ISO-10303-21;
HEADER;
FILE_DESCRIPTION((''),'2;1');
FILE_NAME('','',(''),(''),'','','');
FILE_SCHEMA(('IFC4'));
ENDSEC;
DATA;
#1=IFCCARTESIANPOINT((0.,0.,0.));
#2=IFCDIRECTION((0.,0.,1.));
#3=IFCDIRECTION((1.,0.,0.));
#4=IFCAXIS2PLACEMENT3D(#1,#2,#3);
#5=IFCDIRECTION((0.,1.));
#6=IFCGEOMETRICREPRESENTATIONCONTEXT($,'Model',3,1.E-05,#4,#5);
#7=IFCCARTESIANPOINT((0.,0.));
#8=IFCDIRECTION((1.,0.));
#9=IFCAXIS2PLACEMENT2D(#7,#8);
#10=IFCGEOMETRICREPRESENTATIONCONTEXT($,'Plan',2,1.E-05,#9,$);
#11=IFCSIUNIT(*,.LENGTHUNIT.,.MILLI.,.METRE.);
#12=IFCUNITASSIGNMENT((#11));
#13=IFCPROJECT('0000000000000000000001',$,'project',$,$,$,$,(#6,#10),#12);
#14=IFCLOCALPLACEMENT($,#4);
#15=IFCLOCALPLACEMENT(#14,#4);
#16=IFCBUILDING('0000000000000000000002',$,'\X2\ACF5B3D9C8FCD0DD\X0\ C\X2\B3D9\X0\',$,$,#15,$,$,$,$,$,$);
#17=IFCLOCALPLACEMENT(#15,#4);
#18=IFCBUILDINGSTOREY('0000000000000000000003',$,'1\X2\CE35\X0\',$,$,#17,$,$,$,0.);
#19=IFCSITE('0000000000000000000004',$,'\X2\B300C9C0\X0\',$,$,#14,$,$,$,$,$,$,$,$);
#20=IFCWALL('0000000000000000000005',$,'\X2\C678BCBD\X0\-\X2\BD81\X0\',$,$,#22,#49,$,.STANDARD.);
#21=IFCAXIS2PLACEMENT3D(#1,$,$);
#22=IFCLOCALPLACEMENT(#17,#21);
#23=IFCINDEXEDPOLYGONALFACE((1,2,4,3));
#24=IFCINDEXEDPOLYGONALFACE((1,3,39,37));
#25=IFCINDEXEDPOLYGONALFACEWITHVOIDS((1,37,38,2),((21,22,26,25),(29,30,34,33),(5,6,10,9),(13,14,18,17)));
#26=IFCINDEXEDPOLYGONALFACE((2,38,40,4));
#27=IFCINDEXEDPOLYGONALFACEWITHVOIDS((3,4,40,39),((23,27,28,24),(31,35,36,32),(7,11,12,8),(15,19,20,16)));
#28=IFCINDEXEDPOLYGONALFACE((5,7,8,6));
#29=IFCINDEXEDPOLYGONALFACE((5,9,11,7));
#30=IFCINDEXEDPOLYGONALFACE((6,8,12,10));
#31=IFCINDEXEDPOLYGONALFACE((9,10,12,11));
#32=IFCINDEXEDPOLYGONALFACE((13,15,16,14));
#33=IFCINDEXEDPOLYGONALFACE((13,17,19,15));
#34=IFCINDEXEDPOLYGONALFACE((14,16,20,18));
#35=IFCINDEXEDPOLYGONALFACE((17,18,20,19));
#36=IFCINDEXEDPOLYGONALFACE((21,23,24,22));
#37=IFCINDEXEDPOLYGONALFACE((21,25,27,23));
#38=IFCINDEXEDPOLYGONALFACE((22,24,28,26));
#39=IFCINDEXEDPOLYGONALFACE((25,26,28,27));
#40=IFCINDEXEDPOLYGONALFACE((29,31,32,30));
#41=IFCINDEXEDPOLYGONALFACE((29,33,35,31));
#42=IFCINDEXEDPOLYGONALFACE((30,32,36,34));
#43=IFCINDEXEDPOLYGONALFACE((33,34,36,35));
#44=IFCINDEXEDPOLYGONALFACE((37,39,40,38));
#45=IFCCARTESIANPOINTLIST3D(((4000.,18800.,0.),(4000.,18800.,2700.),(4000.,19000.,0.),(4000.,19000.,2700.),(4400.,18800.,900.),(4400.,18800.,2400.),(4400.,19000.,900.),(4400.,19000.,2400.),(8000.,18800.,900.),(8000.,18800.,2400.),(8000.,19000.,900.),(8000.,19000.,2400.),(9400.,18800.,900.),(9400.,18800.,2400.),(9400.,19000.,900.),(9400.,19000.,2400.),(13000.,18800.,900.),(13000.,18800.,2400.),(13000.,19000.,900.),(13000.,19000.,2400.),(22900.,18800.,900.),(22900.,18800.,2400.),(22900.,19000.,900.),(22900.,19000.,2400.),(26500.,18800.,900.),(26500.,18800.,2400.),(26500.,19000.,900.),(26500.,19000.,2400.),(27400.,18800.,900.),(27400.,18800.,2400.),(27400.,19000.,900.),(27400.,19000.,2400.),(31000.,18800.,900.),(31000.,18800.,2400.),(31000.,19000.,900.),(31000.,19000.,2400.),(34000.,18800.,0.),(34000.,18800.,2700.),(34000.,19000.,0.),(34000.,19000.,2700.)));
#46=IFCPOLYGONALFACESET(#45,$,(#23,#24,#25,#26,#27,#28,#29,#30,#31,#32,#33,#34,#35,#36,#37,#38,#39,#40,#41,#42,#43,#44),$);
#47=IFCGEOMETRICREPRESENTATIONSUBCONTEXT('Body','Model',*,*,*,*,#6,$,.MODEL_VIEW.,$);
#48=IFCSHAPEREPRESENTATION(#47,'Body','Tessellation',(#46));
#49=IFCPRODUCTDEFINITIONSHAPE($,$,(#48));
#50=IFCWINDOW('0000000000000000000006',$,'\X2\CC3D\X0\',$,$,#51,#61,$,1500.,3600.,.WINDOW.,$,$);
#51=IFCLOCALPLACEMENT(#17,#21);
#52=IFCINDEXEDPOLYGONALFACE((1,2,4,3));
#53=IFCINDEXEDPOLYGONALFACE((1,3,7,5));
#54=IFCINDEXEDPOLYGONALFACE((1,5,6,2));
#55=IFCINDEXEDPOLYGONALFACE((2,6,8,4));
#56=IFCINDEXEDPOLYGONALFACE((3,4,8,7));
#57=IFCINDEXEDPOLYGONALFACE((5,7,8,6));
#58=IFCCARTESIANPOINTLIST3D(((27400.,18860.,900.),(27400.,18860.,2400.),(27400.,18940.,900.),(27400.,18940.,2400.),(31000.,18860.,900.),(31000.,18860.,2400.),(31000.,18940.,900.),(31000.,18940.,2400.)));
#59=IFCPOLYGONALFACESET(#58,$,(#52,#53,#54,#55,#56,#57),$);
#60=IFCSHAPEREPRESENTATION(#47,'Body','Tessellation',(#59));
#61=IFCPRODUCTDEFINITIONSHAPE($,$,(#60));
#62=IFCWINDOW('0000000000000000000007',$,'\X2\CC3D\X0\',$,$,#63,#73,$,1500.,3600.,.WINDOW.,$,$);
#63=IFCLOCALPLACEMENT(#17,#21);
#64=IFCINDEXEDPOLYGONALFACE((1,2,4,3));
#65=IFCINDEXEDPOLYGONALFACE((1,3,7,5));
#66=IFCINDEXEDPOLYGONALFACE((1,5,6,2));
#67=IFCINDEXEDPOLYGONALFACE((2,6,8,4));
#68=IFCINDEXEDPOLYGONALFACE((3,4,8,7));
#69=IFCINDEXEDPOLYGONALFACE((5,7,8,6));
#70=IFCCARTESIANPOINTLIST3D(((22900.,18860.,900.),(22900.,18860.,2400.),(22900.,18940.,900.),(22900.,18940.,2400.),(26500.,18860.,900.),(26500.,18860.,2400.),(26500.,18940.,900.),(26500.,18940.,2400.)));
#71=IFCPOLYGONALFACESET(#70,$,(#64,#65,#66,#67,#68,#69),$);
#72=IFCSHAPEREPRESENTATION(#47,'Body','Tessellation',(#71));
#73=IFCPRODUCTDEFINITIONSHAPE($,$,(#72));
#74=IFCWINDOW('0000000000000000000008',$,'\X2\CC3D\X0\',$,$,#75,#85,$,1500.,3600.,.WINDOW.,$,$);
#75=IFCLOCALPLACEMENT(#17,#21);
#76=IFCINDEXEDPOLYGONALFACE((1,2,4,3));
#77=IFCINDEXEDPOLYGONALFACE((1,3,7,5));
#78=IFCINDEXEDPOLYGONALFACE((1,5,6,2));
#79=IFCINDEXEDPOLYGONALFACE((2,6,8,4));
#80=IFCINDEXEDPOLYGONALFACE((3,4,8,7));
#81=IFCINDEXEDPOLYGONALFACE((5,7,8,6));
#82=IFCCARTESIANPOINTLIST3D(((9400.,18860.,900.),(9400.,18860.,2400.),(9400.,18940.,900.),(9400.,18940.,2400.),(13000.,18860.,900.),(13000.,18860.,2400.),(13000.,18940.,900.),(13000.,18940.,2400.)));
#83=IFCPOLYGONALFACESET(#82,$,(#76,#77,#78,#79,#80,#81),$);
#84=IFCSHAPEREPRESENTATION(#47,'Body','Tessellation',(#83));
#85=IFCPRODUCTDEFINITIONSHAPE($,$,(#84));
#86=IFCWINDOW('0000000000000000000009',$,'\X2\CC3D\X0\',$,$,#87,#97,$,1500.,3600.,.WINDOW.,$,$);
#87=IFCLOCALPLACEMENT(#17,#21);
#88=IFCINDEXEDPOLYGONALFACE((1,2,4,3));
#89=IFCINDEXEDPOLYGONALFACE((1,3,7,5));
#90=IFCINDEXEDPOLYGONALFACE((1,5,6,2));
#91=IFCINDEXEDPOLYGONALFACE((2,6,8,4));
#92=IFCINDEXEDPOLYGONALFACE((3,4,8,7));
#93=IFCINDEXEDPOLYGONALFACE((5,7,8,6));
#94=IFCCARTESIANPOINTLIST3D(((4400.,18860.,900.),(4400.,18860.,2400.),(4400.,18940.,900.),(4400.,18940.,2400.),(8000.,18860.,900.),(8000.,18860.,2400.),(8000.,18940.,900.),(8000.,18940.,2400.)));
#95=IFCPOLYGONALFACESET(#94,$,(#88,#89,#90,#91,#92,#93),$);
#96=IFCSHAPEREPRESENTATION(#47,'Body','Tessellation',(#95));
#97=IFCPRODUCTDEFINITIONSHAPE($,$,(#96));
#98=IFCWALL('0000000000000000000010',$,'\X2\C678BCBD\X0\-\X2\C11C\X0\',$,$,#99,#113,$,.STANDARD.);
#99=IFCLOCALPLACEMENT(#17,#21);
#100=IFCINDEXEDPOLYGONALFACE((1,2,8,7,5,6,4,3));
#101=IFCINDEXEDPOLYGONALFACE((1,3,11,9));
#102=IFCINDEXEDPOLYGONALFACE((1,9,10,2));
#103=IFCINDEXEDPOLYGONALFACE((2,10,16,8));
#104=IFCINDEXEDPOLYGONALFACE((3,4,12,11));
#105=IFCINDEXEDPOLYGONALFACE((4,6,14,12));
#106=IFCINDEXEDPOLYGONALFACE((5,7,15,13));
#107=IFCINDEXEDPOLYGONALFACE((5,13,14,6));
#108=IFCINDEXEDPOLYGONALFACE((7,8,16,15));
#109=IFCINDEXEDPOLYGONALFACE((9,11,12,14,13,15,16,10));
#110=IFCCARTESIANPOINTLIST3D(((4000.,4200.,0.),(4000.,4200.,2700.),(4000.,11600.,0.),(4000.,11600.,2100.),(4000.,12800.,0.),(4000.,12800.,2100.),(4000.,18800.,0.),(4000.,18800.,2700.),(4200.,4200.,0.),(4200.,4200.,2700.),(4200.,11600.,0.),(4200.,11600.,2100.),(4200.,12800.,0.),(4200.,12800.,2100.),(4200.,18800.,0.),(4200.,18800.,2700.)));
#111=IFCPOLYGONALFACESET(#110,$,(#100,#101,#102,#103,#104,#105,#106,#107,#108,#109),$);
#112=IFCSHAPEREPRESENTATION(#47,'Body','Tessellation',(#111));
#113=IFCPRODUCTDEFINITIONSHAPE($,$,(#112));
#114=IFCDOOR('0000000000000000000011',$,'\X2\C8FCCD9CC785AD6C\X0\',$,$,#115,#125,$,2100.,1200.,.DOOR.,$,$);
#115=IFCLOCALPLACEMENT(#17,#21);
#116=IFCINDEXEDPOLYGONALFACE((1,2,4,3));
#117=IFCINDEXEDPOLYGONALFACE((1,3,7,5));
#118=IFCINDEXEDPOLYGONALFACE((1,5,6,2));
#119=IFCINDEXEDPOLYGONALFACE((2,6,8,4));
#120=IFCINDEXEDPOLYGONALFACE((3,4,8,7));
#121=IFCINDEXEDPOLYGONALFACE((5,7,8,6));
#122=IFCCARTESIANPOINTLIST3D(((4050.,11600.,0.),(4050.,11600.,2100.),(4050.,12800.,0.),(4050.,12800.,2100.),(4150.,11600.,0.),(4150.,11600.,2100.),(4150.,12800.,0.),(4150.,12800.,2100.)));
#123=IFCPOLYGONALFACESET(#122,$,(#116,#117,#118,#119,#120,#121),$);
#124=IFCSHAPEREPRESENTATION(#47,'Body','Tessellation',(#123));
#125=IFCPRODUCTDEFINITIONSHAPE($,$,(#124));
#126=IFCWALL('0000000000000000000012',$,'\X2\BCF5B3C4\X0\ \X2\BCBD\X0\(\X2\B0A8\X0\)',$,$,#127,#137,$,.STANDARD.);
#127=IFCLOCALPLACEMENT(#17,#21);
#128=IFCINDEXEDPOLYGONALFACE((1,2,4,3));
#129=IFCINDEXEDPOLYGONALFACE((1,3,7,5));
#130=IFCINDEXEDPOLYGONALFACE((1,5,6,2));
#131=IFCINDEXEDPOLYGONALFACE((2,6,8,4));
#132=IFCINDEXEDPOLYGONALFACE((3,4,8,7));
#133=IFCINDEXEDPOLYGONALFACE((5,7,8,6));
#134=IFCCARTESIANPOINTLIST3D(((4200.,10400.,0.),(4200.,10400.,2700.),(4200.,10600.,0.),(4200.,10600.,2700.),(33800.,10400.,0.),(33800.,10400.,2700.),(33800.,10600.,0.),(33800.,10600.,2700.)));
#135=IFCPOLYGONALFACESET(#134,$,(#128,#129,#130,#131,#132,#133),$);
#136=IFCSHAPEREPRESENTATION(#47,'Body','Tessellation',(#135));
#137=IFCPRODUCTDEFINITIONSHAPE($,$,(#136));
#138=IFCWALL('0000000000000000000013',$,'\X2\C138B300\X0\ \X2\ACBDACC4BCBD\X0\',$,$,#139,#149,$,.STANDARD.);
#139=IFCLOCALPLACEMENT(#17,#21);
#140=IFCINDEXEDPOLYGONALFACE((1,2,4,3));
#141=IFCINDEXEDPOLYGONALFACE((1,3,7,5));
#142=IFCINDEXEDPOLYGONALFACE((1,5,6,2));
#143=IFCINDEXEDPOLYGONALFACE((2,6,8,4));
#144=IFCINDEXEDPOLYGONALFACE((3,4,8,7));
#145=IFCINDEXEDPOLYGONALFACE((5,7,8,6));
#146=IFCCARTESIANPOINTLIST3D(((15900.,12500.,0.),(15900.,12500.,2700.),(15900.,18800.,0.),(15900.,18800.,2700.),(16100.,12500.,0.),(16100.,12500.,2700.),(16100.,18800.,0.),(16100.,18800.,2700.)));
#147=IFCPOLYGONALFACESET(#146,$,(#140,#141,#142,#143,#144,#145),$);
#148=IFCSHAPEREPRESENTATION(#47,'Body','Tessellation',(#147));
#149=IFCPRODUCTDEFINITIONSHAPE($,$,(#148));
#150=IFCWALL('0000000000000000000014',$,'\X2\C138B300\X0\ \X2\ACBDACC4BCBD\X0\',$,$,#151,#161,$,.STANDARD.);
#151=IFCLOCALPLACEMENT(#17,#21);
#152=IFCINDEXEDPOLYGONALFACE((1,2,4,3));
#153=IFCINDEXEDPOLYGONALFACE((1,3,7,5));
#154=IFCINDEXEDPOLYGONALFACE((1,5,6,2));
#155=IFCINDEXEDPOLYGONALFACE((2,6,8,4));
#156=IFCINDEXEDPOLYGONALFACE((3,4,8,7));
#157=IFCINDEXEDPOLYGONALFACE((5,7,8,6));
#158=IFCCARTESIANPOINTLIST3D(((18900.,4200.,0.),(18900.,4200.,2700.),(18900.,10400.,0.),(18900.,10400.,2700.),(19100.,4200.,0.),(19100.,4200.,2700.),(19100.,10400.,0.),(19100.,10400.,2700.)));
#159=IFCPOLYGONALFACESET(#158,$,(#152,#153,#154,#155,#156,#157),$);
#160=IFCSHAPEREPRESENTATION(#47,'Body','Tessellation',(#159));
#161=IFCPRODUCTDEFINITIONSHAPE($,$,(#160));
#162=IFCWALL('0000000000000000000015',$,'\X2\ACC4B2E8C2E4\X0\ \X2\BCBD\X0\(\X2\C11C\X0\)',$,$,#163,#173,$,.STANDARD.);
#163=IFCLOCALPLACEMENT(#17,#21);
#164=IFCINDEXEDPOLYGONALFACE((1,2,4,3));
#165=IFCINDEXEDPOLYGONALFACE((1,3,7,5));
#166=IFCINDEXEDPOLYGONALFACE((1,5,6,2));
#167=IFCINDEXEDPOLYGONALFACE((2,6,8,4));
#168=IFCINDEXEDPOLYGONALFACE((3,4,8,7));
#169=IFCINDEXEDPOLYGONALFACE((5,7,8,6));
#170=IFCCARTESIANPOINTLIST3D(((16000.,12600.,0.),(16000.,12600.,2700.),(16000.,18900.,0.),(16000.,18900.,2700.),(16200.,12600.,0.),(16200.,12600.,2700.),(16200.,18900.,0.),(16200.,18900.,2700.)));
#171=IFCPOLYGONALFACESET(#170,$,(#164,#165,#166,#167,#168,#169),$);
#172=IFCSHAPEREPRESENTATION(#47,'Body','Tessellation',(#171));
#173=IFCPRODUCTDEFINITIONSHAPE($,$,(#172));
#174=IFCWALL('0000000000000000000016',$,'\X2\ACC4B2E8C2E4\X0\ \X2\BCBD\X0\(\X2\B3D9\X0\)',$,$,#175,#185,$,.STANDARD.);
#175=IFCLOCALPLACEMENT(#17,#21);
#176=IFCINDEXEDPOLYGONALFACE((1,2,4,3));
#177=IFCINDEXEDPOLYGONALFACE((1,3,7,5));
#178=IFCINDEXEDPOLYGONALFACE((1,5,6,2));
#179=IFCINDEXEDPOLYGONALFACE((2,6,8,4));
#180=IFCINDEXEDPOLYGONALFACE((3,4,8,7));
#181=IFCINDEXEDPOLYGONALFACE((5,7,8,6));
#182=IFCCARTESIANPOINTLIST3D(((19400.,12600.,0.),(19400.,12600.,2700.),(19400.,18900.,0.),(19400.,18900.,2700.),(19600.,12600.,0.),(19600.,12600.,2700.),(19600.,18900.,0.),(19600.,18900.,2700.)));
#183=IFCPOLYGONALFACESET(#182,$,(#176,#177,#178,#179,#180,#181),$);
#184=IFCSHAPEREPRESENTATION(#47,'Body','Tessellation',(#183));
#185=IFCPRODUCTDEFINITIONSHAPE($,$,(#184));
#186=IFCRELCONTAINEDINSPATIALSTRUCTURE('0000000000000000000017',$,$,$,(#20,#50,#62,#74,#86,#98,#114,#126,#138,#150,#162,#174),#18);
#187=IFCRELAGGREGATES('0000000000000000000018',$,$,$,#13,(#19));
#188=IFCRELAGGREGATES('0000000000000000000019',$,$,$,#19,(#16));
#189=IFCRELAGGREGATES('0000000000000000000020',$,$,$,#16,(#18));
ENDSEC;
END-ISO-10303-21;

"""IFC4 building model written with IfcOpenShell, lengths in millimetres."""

from ifc_helpers import new_model, si_unit, direction, frame, origin_with_axes, origin_2d_with_axis, place, context, subcontext, project, spatial, polyline, outline, extrude, element, fill, save


model = new_model("IFC4")

# Units and contexts
model_context = context("Model", 3, precision=1e-05, world=origin_with_axes(), true_north=direction((0.0, 1.0)))
plan_context = context("Plan", 2, precision=1e-05, world=origin_2d_with_axis())
body_context = subcontext(model_context, "Body", "Model", "MODEL_VIEW")
ifc_project = project(units=[si_unit("LENGTHUNIT", "METRE", prefix="MILLI")], contexts=[model_context, plan_context])

# Site, building, storey
site_placement = place(None, origin_with_axes())
site = spatial("IfcSite", under=ifc_project, at=site_placement, Name="대지")
building_placement = place(site_placement, origin_with_axes())
building = spatial("IfcBuilding", under=site, at=building_placement, Name="공동주택 C동")
storey_placement = place(building_placement, origin_with_axes())
storey = spatial("IfcBuildingStorey", under=building, at=storey_placement, Name="1층", Elevation=0.0)

# Wall, openings, windows
wall_1_placement = place(storey_placement, origin_with_axes())
wall_1 = element("IfcWall", 1, at=wall_1_placement, inside=storey, Name="외벽-북", PredefinedType="STANDARD", context=body_context, shape_type="SweptSolid", body=[
    extrude(outline(polyline([(34000.0, 18800.0), (4000.0, 18800.0), (4000.0, 19000.0), (34000.0, 19000.0), (34000.0, 18800.0)])), origin_with_axes(), (0.0, 0.0, 1.0), 2700.0),
])
opening_1_placement = place(storey_placement, origin_with_axes())
opening_1 = element("IfcOpeningElement", 2, at=opening_1_placement, cuts=wall_1, PredefinedType="OPENING", context=body_context, shape_type="SweptSolid", body=[
    extrude(outline(polyline([(31000.0, 19050.0), (27400.0, 19050.0), (27400.0, 18750.0), (31000.0, 18750.0), (31000.0, 19050.0)])), frame((0.0, 0.0, 900.0), z_axis=(0.0, 0.0, 1.0), x_axis=(1.0, 0.0, 0.0)), (0.0, 0.0, 1.0), 1500.0),
])
opening_2_placement = place(storey_placement, origin_with_axes())
opening_2 = element("IfcOpeningElement", 3, at=opening_2_placement, cuts=wall_1, PredefinedType="OPENING", context=body_context, shape_type="SweptSolid", body=[
    extrude(outline(polyline([(26500.0, 19050.0), (22900.0, 19050.0), (22900.0, 18750.0), (26500.0, 18750.0), (26500.0, 19050.0)])), frame((0.0, 0.0, 900.0), z_axis=(0.0, 0.0, 1.0), x_axis=(1.0, 0.0, 0.0)), (0.0, 0.0, 1.0), 1500.0),
])
opening_3_placement = place(storey_placement, origin_with_axes())
opening_3 = element("IfcOpeningElement", 4, at=opening_3_placement, cuts=wall_1, PredefinedType="OPENING", context=body_context, shape_type="SweptSolid", body=[
    extrude(outline(polyline([(13000.0, 19050.0), (9400.0, 19050.0), (9400.0, 18750.0), (13000.0, 18750.0), (13000.0, 19050.0)])), frame((0.0, 0.0, 900.0), z_axis=(0.0, 0.0, 1.0), x_axis=(1.0, 0.0, 0.0)), (0.0, 0.0, 1.0), 1500.0),
])
opening_4_placement = place(storey_placement, origin_with_axes())
opening_4 = element("IfcOpeningElement", 5, at=opening_4_placement, cuts=wall_1, PredefinedType="OPENING", context=body_context, shape_type="SweptSolid", body=[
    extrude(outline(polyline([(8000.0, 19050.0), (4400.0, 19050.0), (4400.0, 18750.0), (8000.0, 18750.0), (8000.0, 19050.0)])), frame((0.0, 0.0, 900.0), z_axis=(0.0, 0.0, 1.0), x_axis=(1.0, 0.0, 0.0)), (0.0, 0.0, 1.0), 1500.0),
])
window_1_placement = place(storey_placement, origin_with_axes())
window_1 = element("IfcWindow", 6, at=window_1_placement, inside=storey, Name="창", OverallHeight=1500.0, OverallWidth=3600.0, PredefinedType="WINDOW", context=body_context, shape_type="SweptSolid", body=[
    extrude(outline(polyline([(31000.0, 18940.0), (27400.0, 18940.0), (27400.0, 18860.0), (31000.0, 18860.0), (31000.0, 18940.0)])), frame((0.0, 0.0, 900.0), z_axis=(0.0, 0.0, 1.0), x_axis=(1.0, 0.0, 0.0)), (0.0, 0.0, 1.0), 1500.0),
])
fill(opening_1, window_1)
window_2_placement = place(storey_placement, origin_with_axes())
window_2 = element("IfcWindow", 7, at=window_2_placement, inside=storey, Name="창", OverallHeight=1500.0, OverallWidth=3600.0, PredefinedType="WINDOW", context=body_context, shape_type="SweptSolid", body=[
    extrude(outline(polyline([(26500.0, 18940.0), (22900.0, 18940.0), (22900.0, 18860.0), (26500.0, 18860.0), (26500.0, 18940.0)])), frame((0.0, 0.0, 900.0), z_axis=(0.0, 0.0, 1.0), x_axis=(1.0, 0.0, 0.0)), (0.0, 0.0, 1.0), 1500.0),
])
fill(opening_2, window_2)
window_3_placement = place(storey_placement, origin_with_axes())
window_3 = element("IfcWindow", 8, at=window_3_placement, inside=storey, Name="창", OverallHeight=1500.0, OverallWidth=3600.0, PredefinedType="WINDOW", context=body_context, shape_type="SweptSolid", body=[
    extrude(outline(polyline([(13000.0, 18940.0), (9400.0, 18940.0), (9400.0, 18860.0), (13000.0, 18860.0), (13000.0, 18940.0)])), frame((0.0, 0.0, 900.0), z_axis=(0.0, 0.0, 1.0), x_axis=(1.0, 0.0, 0.0)), (0.0, 0.0, 1.0), 1500.0),
])
fill(opening_3, window_3)
window_4_placement = place(storey_placement, origin_with_axes())
window_4 = element("IfcWindow", 9, at=window_4_placement, inside=storey, Name="창", OverallHeight=1500.0, OverallWidth=3600.0, PredefinedType="WINDOW", context=body_context, shape_type="SweptSolid", body=[
    extrude(outline(polyline([(8000.0, 18940.0), (4400.0, 18940.0), (4400.0, 18860.0), (8000.0, 18860.0), (8000.0, 18940.0)])), frame((0.0, 0.0, 900.0), z_axis=(0.0, 0.0, 1.0), x_axis=(1.0, 0.0, 0.0)), (0.0, 0.0, 1.0), 1500.0),
])
fill(opening_4, window_4)

# Wall, opening, door
wall_2_placement = place(storey_placement, origin_with_axes())
wall_2 = element("IfcWall", 10, at=wall_2_placement, inside=storey, Name="외벽-서", PredefinedType="STANDARD", context=body_context, shape_type="SweptSolid", body=[
    extrude(outline(polyline([(4200.0, 18800.0), (4200.0, 4200.0), (4000.0, 4200.0), (4000.0, 18800.0), (4200.0, 18800.0)])), origin_with_axes(), (0.0, 0.0, 1.0), 2700.0),
])
opening_5_placement = place(storey_placement, origin_with_axes())
opening_5 = element("IfcOpeningElement", 11, at=opening_5_placement, cuts=wall_2, PredefinedType="OPENING", context=body_context, shape_type="SweptSolid", body=[
    extrude(outline(polyline([(3950.0, 12800.0), (3950.0, 11600.0), (4250.0, 11600.0), (4250.0, 12800.0), (3950.0, 12800.0)])), origin_with_axes(), (0.0, 0.0, 1.0), 2100.0),
])
door_placement = place(storey_placement, origin_with_axes())
door = element("IfcDoor", 12, at=door_placement, inside=storey, Name="주출입구", OverallHeight=2100.0, OverallWidth=1200.0, PredefinedType="DOOR", context=body_context, shape_type="SweptSolid", body=[
    extrude(outline(polyline([(4050.0, 12800.0), (4050.0, 11600.0), (4150.0, 11600.0), (4150.0, 12800.0), (4050.0, 12800.0)])), origin_with_axes(), (0.0, 0.0, 1.0), 2100.0),
])
fill(opening_5, door)

# Walls
wall_3_placement = place(storey_placement, origin_with_axes())
element("IfcWall", 13, at=wall_3_placement, inside=storey, Name="복도 벽(남)", PredefinedType="STANDARD", context=body_context, shape_type="SweptSolid", body=[
    extrude(outline(polyline([(4200.0, 10600.0), (33800.0, 10600.0), (33800.0, 10400.0), (4200.0, 10400.0), (4200.0, 10600.0)])), origin_with_axes(), (0.0, 0.0, 1.0), 2700.0),
])
wall_4_placement = place(storey_placement, origin_with_axes())
element("IfcWall", 14, at=wall_4_placement, inside=storey, Name="세대 경계벽", PredefinedType="STANDARD", context=body_context, shape_type="SweptSolid", body=[
    extrude(outline(polyline([(15900.0, 12500.0), (15900.0, 18800.0), (16100.0, 18800.0), (16100.0, 12500.0), (15900.0, 12500.0)])), origin_with_axes(), (0.0, 0.0, 1.0), 2700.0),
])
wall_5_placement = place(storey_placement, origin_with_axes())
element("IfcWall", 15, at=wall_5_placement, inside=storey, Name="세대 경계벽", PredefinedType="STANDARD", context=body_context, shape_type="SweptSolid", body=[
    extrude(outline(polyline([(18900.0, 4200.0), (18900.0, 10400.0), (19100.0, 10400.0), (19100.0, 4200.0), (18900.0, 4200.0)])), origin_with_axes(), (0.0, 0.0, 1.0), 2700.0),
])
wall_6_placement = place(storey_placement, origin_with_axes())
element("IfcWall", 16, at=wall_6_placement, inside=storey, Name="계단실 벽(서)", PredefinedType="STANDARD", context=body_context, shape_type="SweptSolid", body=[
    extrude(outline(polyline([(16000.0, 12600.0), (16000.0, 18900.0), (16200.0, 18900.0), (16200.0, 12600.0), (16000.0, 12600.0)])), origin_with_axes(), (0.0, 0.0, 1.0), 2700.0),
])
wall_7_placement = place(storey_placement, origin_with_axes())
element("IfcWall", 17, at=wall_7_placement, inside=storey, Name="계단실 벽(동)", PredefinedType="STANDARD", context=body_context, shape_type="SweptSolid", body=[
    extrude(outline(polyline([(19400.0, 12600.0), (19400.0, 18900.0), (19600.0, 18900.0), (19600.0, 12600.0), (19400.0, 12600.0)])), origin_with_axes(), (0.0, 0.0, 1.0), 2700.0),
])

save(model, "model.ifc")
